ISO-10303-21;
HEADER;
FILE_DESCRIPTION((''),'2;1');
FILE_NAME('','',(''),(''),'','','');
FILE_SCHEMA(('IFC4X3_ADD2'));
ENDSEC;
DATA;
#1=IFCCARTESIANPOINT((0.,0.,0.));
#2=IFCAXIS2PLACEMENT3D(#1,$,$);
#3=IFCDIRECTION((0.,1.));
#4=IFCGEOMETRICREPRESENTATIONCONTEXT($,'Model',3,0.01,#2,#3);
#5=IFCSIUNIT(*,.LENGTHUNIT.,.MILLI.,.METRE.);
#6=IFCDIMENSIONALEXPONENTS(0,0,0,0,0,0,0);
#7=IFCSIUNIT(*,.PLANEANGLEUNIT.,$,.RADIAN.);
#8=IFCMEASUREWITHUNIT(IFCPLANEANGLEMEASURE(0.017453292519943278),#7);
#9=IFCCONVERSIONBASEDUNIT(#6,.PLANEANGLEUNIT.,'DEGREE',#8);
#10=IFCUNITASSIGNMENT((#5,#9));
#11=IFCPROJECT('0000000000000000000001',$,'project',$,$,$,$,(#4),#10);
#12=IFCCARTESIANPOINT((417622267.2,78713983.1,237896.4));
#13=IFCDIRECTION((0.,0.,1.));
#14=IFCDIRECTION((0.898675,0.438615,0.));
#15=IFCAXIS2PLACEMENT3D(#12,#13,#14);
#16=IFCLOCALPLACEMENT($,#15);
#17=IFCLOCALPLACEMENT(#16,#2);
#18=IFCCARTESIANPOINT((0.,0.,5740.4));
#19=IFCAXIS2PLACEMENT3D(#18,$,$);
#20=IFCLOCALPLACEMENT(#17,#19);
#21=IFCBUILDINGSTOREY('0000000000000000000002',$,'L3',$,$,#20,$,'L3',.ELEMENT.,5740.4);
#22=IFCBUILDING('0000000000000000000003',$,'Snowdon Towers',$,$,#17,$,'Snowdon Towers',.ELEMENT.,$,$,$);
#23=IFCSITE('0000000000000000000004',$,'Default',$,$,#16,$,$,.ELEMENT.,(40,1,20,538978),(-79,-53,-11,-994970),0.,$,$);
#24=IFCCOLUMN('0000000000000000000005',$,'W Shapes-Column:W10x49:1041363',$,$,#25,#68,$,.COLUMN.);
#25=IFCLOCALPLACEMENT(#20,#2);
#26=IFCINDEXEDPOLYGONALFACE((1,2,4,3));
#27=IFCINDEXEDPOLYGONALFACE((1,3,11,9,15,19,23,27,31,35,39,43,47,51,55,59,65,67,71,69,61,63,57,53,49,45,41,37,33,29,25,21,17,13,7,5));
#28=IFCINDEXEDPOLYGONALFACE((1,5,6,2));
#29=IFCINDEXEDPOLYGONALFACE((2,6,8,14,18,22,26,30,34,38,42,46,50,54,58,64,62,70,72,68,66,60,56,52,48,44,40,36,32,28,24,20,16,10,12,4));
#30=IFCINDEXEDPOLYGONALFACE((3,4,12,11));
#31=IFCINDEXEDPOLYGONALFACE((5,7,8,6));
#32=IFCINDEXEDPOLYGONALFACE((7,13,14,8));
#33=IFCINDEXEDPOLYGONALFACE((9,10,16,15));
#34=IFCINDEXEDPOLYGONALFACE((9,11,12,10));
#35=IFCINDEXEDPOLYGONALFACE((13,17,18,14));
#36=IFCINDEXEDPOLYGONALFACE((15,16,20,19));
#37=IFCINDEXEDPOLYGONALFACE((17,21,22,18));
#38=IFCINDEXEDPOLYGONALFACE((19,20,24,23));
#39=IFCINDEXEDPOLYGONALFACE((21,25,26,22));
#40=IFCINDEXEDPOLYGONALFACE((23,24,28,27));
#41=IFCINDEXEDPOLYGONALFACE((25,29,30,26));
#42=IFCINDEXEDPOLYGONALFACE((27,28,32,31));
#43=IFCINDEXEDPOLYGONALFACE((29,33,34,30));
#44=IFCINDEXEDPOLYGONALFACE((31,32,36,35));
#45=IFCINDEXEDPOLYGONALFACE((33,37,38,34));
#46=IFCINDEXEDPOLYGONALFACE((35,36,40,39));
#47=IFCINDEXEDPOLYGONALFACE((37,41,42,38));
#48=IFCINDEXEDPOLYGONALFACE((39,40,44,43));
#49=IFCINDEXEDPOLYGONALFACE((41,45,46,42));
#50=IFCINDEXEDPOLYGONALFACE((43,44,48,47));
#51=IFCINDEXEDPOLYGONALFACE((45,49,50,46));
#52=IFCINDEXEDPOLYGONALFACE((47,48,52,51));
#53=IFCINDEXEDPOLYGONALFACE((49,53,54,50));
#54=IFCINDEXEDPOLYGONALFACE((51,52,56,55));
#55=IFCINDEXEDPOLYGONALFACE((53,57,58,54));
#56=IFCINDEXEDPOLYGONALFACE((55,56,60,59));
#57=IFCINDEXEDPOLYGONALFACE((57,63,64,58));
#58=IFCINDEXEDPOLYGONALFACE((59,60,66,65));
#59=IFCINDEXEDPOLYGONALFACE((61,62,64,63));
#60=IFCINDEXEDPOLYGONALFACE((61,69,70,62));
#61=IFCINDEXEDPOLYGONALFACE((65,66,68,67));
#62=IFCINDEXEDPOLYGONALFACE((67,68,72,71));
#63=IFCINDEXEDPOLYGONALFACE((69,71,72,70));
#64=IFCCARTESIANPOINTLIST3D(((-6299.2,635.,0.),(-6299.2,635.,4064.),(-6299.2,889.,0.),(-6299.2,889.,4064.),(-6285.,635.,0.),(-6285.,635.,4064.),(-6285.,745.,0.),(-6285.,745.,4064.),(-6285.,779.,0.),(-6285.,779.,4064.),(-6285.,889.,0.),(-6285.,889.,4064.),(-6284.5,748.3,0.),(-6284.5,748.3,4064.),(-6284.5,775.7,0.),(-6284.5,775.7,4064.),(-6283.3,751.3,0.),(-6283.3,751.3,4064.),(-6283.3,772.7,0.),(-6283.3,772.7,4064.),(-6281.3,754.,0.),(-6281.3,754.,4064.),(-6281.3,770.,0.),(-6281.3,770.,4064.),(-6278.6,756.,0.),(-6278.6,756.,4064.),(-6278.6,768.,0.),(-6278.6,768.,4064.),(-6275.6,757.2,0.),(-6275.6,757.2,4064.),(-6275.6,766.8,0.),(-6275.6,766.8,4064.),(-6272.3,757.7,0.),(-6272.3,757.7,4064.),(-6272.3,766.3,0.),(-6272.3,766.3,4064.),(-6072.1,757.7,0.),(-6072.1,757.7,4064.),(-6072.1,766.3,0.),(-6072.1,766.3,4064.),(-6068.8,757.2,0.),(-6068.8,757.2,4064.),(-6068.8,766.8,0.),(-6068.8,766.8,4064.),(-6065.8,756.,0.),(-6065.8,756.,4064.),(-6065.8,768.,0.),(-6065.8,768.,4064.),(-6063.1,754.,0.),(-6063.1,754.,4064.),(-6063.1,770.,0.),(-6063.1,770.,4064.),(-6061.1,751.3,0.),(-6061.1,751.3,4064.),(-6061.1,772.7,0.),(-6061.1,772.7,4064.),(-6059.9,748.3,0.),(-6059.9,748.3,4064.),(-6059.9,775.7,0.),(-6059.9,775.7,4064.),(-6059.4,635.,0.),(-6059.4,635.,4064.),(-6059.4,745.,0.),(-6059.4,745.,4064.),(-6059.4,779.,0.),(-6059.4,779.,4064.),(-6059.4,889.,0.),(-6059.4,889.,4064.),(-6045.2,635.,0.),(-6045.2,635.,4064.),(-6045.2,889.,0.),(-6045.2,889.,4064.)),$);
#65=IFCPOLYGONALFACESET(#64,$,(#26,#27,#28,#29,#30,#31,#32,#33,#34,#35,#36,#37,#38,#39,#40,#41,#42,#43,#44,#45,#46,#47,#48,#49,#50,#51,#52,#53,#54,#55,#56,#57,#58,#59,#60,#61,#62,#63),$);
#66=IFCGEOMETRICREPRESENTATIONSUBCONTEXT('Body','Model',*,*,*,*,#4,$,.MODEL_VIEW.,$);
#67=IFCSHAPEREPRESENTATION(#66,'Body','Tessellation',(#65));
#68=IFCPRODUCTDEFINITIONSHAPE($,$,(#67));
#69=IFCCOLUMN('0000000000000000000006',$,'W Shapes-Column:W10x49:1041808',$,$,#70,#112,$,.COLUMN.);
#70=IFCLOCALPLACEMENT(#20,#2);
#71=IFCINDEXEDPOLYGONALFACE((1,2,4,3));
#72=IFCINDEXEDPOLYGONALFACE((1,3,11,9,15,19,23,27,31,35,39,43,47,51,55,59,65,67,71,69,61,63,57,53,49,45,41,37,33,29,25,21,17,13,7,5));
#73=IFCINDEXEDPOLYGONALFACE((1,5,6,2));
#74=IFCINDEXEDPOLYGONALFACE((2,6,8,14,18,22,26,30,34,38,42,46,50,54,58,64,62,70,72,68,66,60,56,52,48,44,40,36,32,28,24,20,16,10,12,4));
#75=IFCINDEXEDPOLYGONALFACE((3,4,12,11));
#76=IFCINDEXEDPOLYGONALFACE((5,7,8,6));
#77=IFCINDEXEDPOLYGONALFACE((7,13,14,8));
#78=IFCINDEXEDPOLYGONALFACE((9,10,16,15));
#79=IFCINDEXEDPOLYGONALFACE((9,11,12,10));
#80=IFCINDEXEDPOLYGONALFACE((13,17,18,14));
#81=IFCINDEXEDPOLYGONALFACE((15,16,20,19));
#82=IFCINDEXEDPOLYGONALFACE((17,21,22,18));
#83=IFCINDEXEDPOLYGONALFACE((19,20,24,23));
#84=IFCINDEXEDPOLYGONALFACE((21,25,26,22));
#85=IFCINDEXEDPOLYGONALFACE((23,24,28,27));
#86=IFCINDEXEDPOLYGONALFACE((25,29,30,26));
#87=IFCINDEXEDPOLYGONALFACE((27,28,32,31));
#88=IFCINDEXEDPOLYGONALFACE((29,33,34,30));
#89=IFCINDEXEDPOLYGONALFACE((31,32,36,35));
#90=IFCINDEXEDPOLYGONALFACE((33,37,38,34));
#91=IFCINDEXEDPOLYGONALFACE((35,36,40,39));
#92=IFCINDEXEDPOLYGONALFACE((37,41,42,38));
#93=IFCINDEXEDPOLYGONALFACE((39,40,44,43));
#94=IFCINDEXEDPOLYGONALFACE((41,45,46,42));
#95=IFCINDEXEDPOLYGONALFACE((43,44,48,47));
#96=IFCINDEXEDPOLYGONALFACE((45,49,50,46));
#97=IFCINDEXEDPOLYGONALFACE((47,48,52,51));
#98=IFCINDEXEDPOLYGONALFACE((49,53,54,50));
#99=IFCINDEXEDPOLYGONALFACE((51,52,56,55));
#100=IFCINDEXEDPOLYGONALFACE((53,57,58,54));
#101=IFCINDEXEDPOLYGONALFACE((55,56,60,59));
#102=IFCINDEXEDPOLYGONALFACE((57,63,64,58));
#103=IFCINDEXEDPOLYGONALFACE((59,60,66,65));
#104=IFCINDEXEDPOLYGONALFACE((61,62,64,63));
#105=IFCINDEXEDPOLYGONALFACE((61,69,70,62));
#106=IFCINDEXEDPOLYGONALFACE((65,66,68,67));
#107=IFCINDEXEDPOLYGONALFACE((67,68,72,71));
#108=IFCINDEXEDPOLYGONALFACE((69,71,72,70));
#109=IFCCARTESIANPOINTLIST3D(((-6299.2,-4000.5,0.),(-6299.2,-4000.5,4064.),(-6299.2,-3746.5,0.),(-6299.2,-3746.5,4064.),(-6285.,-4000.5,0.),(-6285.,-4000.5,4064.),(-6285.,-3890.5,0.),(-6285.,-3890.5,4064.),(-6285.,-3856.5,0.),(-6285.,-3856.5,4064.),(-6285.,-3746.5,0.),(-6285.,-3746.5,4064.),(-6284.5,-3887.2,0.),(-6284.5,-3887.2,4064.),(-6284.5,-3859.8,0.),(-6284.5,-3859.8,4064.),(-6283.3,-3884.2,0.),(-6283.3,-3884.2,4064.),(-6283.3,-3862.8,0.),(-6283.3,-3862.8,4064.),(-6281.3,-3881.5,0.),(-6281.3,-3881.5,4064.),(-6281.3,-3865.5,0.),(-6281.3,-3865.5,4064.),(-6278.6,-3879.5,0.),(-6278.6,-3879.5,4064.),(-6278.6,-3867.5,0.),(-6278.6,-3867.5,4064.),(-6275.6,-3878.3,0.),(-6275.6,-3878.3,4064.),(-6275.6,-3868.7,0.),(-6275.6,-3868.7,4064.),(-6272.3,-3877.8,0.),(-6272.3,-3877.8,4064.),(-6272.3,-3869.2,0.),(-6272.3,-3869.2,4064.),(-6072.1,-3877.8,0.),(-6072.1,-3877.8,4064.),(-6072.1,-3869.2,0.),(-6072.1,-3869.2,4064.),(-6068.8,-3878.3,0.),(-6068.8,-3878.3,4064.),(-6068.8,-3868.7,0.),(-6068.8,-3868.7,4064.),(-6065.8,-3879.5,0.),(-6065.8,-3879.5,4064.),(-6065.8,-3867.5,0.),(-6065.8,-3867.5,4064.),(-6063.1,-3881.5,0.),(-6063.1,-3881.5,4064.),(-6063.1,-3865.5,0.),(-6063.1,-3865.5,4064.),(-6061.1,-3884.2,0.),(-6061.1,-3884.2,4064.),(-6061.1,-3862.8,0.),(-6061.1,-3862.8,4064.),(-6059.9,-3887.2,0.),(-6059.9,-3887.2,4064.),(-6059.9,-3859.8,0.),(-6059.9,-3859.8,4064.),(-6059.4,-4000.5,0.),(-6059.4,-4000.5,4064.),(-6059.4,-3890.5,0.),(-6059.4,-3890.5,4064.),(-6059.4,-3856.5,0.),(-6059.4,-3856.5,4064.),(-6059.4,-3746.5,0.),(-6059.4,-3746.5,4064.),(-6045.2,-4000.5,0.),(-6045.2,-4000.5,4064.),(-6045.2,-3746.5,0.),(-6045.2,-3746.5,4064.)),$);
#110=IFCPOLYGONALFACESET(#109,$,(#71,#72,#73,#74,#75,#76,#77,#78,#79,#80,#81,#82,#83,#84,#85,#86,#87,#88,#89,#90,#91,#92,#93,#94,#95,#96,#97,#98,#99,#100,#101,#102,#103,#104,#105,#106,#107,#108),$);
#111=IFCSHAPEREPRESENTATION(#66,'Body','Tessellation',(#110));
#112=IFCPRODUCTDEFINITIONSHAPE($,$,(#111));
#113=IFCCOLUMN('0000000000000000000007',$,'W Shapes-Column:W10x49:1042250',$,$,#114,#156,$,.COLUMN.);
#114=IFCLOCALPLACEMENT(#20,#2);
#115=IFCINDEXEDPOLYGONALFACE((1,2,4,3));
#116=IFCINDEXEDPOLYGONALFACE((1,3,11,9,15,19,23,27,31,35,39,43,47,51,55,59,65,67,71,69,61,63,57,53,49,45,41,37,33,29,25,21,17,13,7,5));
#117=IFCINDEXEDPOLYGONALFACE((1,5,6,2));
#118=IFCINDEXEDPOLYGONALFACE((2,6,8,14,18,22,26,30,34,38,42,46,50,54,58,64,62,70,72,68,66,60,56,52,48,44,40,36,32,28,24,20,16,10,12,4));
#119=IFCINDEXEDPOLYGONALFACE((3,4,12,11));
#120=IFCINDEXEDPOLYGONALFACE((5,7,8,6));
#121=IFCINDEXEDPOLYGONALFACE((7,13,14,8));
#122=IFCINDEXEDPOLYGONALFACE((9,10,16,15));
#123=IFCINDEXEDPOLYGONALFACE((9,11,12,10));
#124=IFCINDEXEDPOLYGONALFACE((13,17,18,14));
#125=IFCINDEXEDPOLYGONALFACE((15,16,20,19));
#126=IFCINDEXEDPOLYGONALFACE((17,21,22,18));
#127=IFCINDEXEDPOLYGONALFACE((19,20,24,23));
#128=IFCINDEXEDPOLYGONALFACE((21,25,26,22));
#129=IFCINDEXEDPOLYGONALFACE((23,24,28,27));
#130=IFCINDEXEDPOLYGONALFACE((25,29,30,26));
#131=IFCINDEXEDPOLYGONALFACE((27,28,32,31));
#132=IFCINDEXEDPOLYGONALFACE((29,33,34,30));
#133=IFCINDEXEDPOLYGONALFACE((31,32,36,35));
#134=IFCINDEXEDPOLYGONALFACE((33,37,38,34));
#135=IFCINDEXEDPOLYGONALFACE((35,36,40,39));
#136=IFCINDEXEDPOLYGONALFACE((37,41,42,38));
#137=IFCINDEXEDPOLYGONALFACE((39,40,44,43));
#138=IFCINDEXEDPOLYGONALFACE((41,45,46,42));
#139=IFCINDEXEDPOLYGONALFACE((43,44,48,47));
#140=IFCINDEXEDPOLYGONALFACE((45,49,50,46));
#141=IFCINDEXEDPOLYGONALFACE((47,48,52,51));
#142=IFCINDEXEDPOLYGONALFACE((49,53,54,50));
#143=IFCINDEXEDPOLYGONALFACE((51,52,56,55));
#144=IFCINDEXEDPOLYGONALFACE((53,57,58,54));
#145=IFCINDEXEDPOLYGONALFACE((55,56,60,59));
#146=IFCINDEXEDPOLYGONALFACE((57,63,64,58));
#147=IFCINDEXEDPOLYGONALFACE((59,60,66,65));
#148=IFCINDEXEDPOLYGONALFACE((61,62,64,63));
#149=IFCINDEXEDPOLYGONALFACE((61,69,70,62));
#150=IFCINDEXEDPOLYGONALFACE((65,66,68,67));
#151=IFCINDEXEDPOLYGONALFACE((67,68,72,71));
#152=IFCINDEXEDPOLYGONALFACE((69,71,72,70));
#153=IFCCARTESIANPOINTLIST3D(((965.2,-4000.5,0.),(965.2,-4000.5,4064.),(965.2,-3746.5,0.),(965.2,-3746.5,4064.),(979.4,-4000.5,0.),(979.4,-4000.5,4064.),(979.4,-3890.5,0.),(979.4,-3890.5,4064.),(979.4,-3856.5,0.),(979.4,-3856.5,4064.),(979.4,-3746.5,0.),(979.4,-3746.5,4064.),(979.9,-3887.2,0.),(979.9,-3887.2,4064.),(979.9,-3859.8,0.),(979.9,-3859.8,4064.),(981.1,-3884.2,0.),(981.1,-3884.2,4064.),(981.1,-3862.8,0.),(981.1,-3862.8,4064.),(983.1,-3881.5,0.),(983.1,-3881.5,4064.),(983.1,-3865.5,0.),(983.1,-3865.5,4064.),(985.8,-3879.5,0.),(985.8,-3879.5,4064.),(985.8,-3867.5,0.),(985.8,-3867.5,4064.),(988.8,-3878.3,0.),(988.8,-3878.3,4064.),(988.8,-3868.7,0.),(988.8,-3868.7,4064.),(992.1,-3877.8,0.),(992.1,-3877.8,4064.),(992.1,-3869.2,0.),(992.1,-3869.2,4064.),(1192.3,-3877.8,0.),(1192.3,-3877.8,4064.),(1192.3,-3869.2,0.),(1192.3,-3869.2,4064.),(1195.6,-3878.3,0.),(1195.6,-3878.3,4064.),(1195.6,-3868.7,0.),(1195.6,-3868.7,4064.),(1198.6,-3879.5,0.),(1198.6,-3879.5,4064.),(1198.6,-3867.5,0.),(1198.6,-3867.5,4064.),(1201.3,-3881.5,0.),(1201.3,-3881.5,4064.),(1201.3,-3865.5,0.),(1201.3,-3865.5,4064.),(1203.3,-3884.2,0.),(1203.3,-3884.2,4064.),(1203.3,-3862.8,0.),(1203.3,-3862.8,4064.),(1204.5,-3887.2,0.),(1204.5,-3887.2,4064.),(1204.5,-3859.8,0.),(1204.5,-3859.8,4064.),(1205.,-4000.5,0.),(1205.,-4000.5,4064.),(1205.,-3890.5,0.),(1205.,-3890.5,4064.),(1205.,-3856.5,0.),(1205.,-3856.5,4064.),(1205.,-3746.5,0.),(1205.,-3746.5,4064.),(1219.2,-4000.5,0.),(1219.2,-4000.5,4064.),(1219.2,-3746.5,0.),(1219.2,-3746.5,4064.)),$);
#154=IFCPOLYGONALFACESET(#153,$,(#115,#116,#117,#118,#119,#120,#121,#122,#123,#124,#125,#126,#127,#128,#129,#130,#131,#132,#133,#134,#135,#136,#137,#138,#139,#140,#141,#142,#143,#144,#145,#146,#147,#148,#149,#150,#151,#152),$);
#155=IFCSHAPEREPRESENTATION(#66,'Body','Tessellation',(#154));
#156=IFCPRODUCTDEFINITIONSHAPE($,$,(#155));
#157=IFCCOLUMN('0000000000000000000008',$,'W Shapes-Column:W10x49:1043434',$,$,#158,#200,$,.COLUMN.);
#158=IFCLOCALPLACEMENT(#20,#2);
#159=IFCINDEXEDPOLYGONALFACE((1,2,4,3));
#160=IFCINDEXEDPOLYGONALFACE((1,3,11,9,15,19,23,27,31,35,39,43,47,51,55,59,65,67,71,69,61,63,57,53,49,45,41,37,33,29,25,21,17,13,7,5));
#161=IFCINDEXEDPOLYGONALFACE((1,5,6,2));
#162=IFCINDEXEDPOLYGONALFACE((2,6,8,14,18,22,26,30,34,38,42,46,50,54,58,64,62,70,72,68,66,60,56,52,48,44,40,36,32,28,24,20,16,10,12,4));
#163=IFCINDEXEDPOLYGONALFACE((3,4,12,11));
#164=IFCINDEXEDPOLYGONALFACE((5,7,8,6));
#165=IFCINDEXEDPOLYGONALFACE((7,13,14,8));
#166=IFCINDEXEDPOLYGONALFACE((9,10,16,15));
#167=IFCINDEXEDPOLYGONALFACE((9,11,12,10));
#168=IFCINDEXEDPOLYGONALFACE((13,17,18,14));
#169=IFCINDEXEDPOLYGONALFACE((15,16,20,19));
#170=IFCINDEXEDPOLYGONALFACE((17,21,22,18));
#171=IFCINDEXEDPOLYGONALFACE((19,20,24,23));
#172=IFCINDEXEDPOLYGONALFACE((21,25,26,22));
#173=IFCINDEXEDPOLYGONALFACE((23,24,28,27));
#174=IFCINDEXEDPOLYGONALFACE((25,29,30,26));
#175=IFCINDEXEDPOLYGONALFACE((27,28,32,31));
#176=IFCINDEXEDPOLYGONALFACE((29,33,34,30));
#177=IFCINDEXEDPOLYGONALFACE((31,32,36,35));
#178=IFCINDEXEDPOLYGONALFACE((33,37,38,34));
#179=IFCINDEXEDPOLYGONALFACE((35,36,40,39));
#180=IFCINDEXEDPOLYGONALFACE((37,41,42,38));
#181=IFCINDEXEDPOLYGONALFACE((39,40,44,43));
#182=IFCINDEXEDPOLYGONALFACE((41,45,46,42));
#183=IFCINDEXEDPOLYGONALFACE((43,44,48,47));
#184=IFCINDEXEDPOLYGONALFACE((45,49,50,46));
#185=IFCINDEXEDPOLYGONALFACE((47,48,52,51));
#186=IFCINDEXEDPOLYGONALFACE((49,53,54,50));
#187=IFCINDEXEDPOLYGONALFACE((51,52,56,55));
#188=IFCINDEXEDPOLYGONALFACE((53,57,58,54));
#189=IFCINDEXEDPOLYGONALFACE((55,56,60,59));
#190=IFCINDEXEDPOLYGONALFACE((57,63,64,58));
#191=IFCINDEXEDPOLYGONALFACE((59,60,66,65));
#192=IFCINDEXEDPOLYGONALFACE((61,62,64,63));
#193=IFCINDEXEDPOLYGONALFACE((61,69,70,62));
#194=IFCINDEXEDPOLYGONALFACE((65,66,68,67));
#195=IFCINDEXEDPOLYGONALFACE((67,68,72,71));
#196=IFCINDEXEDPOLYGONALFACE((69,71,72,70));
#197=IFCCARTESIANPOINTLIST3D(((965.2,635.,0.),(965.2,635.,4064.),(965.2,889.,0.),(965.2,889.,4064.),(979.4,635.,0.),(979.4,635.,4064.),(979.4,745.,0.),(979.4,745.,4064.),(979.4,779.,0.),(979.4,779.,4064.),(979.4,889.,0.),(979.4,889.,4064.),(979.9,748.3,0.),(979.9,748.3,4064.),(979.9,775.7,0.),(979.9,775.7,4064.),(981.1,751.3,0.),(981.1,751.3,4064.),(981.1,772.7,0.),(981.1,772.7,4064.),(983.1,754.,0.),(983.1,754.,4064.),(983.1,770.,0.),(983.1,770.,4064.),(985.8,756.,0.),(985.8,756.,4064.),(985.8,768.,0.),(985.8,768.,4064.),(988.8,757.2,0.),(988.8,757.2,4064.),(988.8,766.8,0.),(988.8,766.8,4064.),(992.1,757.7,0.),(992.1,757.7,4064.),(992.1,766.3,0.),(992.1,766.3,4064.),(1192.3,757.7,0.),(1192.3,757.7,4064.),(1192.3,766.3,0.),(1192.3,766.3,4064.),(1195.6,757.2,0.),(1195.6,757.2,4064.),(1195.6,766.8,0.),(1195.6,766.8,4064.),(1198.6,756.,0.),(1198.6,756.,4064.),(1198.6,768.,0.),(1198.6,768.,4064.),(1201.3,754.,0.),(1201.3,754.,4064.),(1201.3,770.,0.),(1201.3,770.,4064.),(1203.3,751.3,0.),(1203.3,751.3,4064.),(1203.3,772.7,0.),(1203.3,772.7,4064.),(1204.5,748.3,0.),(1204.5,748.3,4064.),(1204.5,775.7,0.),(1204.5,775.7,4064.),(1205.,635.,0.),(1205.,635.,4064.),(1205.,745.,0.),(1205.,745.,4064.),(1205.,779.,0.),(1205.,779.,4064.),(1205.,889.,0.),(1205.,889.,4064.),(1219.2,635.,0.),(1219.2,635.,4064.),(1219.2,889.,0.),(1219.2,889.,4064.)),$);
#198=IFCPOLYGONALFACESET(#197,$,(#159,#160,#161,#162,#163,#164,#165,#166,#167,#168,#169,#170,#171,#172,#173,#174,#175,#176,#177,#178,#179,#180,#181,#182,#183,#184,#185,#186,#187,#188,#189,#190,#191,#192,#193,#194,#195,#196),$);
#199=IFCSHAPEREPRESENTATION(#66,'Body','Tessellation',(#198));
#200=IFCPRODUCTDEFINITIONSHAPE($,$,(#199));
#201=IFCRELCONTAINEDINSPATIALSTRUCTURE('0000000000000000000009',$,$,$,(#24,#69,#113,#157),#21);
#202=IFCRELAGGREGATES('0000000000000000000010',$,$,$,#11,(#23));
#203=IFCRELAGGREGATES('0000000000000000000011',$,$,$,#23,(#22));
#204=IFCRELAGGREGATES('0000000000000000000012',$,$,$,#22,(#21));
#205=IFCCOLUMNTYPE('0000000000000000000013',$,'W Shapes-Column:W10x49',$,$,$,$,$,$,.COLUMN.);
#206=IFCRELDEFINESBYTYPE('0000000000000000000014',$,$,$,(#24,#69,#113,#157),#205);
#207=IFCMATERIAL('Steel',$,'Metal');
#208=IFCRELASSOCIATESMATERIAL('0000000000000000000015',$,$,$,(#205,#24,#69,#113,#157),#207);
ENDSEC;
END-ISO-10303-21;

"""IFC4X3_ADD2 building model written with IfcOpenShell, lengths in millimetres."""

from ifc_helpers import new_model, entity, si_unit, converted_unit, direction, frame, frame_2d, origin, place, context, subcontext, project, spatial, i_section, extrude, source, transform, mapped, material, material_profile, profile_set, profile_usage, type_object, type_shapes, element, save


model = new_model("IFC4X3_ADD2")

# Units and contexts
model_context = context("Model", 3, precision=0.01, world=origin(), true_north=direction((0.0, 1.0)))
body_context = subcontext(model_context, "Body", "Model", "MODEL_VIEW")
ifc_project = project(units=[si_unit("LENGTHUNIT", "METRE", prefix="MILLI"), converted_unit("PLANEANGLEUNIT", "DEGREE", entity("IfcPlaneAngleMeasure", 0.017453292519943278), si_unit("PLANEANGLEUNIT", "RADIAN"), dimensions=[0, 0, 0, 0, 0, 0, 0])], contexts=[model_context])

# Site, building, storey
site_placement = place(None, frame((417622267.2, 78713983.1, 237896.4), z_axis=(0.0, 0.0, 1.0), x_axis=(0.898675, 0.438615, 0.0)))
site = spatial("IfcSite", under=ifc_project, at=site_placement, Name="Default", CompositionType="ELEMENT", RefLatitude=(40, 1, 20, 538978), RefLongitude=(-79, -53, -11, -994970), RefElevation=0.0)
building_placement = place(site_placement, origin())
building = spatial("IfcBuilding", under=site, at=building_placement, Name="Snowdon Towers", LongName="Snowdon Towers", CompositionType="ELEMENT")
storey_placement = place(building_placement, frame((0.0, 0.0, 5740.4)))
storey = spatial("IfcBuildingStorey", under=building, at=storey_placement, Name="L3", LongName="L3", CompositionType="ELEMENT", Elevation=5740.4)

# Columns
ifc_material_1 = material(Name="Steel", Category="Metal")
ifc_material_profile_1 = material_profile(ifc_material_1, i_section(OverallWidth=254.0, OverallDepth=254.0, WebThickness=8.6, FlangeThickness=14.2, FilletRadius=12.7, at=frame_2d((0.0, 0.0), x_axis=(1.0, 0.0))), Name="W10x49")
ifc_profile_set_1 = profile_set([ifc_material_profile_1], Name="W10x49")
ifc_profile_usage_1 = profile_usage(ifc_profile_set_1)
column_type_1 = type_object("IfcColumnType", Name="W Shapes-Column:W10x49", PredefinedType="COLUMN", material=ifc_profile_set_1)
shared_shape_1 = source(origin(), body_context, "Body", "SweptSolid", [
    extrude(i_section(OverallWidth=254.0, OverallDepth=254.0, WebThickness=8.6, FlangeThickness=14.2, FilletRadius=12.7, at=frame_2d((0.0, 0.0), x_axis=(1.0, 0.0))), frame((0.0, 0.0, 5740.4), z_axis=(0.0, 0.0, 1.0), x_axis=(-1.0, 0.0, 0.0)), (0.0, 0.0, 1.0), 4064.0),
])
type_shapes(column_type_1, [shared_shape_1])
for number, where, z_axis, x_axis, name in (
    (1, (-6172.2, 762.0, -5740.4), (0.0, 0.0, 1.0), (0.0, 1.0, 0.0), "W Shapes-Column:W10x49:1041363"),
    (2, (-6172.2, -3873.5, -5740.4), (0.0, 0.0, 1.0), (0.0, 1.0, 0.0), "W Shapes-Column:W10x49:1041808"),
    (3, (1092.2, -3873.5, -5740.4), (0.0, 0.0, 1.0), (0.0, 1.0, 0.0), "W Shapes-Column:W10x49:1042250"),
    (4, (1092.2, 762.0, -5740.4), (0.0, 0.0, 1.0), (0.0, 1.0, 0.0), "W Shapes-Column:W10x49:1043434"),
):
    element("IfcColumn", number, at=place(storey_placement, frame(where, z_axis=z_axis, x_axis=x_axis)), inside=storey, type_object=column_type_1, material=ifc_profile_usage_1, Name=name, PredefinedType="COLUMN", context=body_context, shape_type="MappedRepresentation", body=[
        mapped(shared_shape_1, transform((0.0, 0.0, 0.0), scale=1.0)),
    ])

save(model, "model.ifc")
